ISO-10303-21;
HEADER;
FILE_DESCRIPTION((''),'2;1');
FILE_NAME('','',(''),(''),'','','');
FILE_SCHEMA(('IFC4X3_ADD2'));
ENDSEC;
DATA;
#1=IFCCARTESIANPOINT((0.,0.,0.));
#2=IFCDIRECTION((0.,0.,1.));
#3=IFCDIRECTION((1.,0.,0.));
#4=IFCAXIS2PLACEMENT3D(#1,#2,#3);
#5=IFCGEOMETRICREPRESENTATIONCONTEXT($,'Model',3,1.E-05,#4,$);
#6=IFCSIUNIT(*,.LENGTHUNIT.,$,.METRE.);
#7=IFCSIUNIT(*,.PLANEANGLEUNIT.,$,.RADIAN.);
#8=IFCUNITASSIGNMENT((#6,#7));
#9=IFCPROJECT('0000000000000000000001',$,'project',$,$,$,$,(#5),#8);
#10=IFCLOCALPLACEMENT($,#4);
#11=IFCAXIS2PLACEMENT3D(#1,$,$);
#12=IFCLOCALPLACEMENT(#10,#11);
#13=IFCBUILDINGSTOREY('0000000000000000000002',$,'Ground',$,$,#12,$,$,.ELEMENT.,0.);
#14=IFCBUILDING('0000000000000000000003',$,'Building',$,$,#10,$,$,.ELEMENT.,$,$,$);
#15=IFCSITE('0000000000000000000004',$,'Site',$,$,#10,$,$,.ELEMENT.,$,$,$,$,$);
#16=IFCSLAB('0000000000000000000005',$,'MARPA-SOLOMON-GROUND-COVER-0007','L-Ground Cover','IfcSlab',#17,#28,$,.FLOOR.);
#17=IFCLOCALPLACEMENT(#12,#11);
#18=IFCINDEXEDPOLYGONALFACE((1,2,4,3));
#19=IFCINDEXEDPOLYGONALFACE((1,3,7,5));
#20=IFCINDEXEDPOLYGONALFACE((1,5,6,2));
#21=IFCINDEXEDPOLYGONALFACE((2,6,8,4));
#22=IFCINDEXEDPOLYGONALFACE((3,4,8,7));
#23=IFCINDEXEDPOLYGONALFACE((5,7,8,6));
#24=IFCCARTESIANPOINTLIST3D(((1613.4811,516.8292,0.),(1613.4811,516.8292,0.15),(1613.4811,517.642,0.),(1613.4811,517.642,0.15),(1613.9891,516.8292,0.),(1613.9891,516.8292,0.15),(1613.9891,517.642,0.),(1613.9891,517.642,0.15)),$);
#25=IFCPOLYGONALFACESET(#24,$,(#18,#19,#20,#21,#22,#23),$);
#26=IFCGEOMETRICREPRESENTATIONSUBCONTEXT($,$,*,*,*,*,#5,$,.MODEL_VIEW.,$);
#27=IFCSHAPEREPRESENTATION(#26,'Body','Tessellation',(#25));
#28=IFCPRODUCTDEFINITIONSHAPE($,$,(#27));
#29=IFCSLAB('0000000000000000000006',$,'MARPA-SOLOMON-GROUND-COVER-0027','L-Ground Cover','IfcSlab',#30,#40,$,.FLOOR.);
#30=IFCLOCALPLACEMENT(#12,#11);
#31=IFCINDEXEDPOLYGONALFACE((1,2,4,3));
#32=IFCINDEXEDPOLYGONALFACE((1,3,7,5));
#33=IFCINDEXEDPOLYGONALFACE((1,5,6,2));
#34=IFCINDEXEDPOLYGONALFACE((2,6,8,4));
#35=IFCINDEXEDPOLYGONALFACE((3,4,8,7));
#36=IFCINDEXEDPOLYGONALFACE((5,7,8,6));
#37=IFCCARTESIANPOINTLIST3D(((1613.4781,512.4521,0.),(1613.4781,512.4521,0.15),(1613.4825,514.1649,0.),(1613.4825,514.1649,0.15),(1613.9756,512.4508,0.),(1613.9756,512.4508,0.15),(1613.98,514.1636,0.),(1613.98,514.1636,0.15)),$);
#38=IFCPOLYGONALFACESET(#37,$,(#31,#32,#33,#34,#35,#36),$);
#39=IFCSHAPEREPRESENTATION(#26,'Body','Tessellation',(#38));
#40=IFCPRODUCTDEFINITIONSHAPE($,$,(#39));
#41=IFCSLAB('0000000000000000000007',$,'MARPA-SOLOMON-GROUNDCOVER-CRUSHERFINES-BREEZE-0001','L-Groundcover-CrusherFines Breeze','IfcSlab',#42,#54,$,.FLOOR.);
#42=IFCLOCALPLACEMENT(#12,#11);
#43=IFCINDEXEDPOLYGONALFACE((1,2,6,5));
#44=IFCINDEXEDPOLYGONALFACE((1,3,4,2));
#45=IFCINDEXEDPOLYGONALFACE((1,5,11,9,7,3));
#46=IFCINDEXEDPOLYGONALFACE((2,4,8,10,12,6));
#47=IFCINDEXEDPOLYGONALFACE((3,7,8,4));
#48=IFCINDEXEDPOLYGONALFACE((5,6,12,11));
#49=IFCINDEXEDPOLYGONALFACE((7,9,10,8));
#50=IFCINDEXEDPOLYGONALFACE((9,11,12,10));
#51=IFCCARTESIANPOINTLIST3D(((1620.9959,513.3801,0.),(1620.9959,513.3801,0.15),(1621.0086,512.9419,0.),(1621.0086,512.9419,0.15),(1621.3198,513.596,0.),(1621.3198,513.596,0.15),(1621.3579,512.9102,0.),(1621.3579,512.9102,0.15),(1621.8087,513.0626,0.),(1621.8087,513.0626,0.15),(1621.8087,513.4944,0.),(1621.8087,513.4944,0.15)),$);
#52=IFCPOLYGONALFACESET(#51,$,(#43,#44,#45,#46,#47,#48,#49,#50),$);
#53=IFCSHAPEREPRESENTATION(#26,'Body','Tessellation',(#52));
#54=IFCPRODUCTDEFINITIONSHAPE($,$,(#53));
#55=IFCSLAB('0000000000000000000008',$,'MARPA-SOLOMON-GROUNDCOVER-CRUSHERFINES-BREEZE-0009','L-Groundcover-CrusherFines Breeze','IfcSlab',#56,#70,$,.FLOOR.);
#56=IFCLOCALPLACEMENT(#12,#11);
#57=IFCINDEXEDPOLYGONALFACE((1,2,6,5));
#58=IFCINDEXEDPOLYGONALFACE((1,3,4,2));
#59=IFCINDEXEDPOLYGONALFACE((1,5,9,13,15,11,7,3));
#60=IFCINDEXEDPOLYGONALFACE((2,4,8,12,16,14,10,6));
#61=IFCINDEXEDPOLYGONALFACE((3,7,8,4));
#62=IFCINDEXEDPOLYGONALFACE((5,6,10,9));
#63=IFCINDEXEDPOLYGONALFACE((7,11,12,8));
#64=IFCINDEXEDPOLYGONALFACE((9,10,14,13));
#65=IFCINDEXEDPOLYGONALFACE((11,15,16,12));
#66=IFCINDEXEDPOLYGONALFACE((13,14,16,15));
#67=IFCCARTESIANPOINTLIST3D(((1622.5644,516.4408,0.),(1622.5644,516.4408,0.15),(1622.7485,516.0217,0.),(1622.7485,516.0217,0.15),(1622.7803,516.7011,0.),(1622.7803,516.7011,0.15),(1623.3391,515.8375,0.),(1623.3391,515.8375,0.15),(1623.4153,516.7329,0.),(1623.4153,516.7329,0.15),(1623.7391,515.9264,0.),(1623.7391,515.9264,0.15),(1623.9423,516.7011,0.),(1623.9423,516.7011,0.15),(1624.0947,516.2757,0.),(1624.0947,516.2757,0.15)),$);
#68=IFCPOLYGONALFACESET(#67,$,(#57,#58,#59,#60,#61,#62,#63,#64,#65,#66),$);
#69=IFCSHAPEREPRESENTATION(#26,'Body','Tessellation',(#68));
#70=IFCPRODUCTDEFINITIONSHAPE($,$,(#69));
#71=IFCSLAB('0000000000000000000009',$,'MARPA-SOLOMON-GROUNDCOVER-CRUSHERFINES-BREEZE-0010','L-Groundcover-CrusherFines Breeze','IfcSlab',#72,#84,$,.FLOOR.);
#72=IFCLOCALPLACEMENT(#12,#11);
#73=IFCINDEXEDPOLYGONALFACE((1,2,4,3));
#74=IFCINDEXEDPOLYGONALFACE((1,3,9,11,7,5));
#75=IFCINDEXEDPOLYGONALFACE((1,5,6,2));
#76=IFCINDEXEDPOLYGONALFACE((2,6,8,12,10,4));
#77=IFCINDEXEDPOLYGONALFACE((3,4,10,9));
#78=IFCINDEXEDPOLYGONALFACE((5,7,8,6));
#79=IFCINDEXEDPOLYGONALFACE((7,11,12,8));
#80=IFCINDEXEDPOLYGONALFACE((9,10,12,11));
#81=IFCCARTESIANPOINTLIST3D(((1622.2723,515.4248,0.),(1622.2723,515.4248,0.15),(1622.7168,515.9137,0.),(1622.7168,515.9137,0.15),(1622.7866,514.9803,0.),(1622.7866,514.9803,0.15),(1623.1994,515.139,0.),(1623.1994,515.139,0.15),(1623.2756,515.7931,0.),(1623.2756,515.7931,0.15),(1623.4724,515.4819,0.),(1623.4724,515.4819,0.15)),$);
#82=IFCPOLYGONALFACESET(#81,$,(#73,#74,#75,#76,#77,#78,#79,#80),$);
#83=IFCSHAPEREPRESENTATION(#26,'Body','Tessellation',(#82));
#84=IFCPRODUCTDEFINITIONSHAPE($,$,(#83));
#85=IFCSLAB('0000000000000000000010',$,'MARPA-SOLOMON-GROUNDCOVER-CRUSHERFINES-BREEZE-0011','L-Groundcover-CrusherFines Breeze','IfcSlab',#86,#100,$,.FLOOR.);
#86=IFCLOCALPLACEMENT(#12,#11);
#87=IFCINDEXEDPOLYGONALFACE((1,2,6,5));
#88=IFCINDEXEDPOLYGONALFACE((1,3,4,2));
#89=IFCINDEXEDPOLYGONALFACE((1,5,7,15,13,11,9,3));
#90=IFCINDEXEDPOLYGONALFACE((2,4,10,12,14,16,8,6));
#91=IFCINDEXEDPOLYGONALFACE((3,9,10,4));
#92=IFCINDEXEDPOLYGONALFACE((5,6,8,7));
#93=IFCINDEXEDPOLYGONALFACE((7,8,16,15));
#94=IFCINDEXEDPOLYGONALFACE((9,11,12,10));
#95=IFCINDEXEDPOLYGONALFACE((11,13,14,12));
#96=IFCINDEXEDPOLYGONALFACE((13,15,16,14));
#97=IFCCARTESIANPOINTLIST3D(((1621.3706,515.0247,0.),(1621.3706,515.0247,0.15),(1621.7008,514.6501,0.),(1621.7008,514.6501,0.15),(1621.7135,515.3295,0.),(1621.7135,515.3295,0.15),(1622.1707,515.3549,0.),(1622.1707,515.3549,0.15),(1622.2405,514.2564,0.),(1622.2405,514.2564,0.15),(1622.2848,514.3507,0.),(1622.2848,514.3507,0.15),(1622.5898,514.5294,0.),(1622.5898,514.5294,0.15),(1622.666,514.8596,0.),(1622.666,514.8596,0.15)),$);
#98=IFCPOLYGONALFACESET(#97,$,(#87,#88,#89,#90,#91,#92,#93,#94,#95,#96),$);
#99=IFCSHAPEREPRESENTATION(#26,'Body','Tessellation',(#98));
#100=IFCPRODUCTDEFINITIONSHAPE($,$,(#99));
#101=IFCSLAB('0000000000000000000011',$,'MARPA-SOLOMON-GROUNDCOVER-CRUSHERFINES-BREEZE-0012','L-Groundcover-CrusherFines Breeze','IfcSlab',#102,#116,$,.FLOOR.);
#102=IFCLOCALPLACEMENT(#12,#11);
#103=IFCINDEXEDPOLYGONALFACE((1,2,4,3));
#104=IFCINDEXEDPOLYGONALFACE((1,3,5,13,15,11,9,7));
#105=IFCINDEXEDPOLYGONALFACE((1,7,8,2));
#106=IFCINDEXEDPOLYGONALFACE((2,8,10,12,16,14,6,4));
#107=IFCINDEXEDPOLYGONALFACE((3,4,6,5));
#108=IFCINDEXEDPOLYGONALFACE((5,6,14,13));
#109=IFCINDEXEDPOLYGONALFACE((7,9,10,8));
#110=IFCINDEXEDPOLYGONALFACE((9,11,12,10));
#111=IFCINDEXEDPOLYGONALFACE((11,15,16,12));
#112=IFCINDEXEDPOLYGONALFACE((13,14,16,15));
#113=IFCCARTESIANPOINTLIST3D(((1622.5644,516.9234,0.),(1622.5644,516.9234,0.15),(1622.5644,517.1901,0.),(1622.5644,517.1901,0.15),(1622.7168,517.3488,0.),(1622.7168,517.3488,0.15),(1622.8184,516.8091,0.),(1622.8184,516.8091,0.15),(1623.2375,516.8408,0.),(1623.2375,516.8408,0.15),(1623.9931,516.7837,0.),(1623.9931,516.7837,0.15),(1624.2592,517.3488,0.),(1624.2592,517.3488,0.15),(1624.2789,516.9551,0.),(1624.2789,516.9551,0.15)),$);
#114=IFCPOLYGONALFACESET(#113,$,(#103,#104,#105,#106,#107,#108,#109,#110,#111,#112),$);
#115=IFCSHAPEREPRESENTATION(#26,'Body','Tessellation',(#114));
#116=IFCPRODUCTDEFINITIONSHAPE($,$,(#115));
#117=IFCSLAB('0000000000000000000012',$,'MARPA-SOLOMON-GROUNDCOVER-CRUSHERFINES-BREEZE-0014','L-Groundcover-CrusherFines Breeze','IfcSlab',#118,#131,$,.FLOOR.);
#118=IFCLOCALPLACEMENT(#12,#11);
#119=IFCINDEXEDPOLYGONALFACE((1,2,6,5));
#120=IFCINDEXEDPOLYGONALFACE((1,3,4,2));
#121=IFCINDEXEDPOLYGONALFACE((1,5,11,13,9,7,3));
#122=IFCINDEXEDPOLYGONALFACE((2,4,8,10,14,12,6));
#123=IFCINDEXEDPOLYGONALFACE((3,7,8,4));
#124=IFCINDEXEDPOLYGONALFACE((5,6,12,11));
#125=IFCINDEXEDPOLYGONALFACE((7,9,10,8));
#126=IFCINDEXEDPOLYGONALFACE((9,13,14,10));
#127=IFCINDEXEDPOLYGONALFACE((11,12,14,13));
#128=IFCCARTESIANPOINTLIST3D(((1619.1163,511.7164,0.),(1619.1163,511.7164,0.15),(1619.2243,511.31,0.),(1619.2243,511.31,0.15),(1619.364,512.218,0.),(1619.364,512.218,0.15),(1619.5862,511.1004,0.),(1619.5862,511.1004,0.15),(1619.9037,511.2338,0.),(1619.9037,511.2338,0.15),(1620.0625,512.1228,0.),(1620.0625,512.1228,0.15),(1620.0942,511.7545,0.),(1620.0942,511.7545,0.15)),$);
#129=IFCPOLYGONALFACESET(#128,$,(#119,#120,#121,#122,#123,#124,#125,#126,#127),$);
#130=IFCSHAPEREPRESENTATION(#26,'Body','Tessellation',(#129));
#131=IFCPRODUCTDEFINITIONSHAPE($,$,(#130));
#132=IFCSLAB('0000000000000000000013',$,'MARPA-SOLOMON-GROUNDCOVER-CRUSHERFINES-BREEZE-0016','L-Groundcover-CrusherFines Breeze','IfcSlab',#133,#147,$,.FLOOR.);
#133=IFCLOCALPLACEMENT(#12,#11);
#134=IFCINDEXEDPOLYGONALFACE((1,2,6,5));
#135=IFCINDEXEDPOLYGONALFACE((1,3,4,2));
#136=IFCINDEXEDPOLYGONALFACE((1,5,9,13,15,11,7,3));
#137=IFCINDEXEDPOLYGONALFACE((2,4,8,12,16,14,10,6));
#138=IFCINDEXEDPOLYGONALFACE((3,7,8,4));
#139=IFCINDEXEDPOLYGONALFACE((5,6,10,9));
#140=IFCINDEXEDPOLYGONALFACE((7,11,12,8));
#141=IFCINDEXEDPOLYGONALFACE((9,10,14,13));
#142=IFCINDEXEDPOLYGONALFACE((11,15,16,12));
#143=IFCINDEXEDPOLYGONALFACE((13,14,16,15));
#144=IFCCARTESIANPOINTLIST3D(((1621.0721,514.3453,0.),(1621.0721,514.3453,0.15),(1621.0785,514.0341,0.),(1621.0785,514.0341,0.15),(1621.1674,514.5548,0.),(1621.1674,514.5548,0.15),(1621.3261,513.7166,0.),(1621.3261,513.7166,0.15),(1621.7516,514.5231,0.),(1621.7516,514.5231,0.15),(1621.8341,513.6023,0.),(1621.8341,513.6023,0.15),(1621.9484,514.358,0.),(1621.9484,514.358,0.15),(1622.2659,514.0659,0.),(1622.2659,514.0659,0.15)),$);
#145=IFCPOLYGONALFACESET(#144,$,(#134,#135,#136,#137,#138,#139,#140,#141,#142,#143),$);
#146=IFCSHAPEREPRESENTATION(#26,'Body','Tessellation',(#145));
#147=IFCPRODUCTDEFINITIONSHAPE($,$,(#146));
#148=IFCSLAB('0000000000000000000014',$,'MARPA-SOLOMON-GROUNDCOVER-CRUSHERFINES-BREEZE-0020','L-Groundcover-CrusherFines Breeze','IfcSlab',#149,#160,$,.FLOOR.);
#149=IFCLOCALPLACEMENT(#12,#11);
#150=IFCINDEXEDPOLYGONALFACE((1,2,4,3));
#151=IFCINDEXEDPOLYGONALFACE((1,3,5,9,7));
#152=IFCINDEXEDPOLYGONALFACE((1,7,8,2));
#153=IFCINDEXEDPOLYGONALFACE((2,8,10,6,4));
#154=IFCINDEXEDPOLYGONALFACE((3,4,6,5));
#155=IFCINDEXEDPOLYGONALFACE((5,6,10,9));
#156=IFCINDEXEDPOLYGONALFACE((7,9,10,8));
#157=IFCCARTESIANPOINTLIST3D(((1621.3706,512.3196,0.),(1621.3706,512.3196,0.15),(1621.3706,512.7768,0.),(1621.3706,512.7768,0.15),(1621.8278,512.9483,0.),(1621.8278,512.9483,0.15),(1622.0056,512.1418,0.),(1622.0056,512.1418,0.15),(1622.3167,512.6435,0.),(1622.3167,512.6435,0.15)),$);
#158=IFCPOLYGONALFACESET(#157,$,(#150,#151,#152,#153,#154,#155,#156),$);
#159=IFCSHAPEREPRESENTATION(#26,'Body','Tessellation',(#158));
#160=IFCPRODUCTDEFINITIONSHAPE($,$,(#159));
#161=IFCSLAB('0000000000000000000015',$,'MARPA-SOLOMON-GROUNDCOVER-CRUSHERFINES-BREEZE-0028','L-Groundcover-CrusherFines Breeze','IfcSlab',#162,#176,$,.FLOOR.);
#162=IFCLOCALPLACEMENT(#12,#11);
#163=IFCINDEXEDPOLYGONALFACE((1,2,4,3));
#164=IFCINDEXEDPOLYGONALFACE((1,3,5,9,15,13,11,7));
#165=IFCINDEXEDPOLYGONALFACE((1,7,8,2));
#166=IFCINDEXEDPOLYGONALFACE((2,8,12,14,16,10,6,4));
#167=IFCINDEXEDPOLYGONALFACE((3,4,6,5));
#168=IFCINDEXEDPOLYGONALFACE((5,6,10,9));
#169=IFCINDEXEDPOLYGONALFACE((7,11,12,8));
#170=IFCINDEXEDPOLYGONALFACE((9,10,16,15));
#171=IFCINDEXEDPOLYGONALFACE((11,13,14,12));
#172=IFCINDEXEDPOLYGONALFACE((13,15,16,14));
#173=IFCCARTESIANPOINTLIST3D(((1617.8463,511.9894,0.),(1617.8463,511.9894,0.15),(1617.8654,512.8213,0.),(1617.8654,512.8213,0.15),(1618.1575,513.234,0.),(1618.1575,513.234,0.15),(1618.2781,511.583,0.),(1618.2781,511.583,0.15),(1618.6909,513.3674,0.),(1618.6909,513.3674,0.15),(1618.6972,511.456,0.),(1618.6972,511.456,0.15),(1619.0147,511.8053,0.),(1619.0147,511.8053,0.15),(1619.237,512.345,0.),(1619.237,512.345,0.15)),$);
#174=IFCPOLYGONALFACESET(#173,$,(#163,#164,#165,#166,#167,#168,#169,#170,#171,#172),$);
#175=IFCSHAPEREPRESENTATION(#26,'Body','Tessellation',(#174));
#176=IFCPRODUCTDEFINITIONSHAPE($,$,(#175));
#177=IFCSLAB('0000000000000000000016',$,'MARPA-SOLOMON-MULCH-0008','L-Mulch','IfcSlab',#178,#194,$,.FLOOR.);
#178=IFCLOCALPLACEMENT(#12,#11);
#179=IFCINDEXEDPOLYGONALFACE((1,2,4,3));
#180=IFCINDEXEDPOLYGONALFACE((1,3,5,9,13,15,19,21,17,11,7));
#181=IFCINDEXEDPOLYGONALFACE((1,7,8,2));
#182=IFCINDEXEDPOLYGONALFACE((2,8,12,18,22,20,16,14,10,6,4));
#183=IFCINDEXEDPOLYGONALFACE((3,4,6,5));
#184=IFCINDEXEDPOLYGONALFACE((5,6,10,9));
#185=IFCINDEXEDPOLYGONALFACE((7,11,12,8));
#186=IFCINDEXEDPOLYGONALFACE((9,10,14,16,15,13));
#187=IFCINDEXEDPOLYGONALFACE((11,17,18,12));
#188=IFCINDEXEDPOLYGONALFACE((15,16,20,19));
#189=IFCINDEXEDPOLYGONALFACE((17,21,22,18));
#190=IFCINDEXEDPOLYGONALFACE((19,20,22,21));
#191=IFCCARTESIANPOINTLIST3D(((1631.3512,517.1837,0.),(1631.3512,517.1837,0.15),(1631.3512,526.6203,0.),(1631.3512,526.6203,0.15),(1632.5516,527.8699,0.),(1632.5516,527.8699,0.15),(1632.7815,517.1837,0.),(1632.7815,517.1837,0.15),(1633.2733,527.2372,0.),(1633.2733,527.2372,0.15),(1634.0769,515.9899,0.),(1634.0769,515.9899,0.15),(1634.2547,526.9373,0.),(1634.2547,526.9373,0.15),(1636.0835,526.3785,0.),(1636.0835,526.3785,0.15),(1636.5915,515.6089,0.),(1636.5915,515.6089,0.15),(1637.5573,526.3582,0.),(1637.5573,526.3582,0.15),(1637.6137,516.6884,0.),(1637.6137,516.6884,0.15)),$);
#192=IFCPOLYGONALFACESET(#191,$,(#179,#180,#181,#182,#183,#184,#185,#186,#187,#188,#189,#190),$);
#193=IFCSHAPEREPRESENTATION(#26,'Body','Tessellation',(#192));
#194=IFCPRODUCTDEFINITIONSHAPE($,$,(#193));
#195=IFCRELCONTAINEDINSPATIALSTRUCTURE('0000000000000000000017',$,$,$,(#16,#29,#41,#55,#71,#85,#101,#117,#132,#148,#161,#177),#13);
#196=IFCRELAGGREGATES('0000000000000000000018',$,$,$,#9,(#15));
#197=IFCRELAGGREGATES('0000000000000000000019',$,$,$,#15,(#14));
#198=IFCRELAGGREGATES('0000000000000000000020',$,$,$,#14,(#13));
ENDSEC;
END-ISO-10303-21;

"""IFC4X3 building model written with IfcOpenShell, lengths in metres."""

from ifc_helpers import new_model, si_unit, frame, origin, origin_with_axes, place, context, subcontext, project, spatial, polyline, outline, extrude, element, save


model = new_model("IFC4X3")

# Units and contexts
model_context = context("Model", 3, precision=1e-05, world=origin_with_axes())
sub_context = subcontext(model_context, None, None, "MODEL_VIEW")
ifc_project = project(units=[si_unit("LENGTHUNIT", "METRE"), si_unit("PLANEANGLEUNIT", "RADIAN")], contexts=[model_context])

# Site, building, storey
placement = place(None, origin_with_axes())
site = spatial("IfcSite", under=ifc_project, at=placement, Name="Site", CompositionType="ELEMENT")
building = spatial("IfcBuilding", under=site, at=placement, Name="Building", CompositionType="ELEMENT")
storey_placement = place(placement, origin())
storey = spatial("IfcBuildingStorey", under=building, at=storey_placement, Name="Ground", CompositionType="ELEMENT", Elevation=0.0)

# Slabs
slab_1_placement = place(storey_placement, frame((1613.4811, 516.8292, 0.0)))
element("IfcSlab", 1, at=slab_1_placement, inside=storey, Name="MARPA-SOLOMON-GROUND-COVER-0007", Description="L-Ground Cover", ObjectType="IfcSlab", PredefinedType="FLOOR", context=sub_context, shape_type="SweptSolid", body=[
    extrude(outline(polyline([(0.0, 0.8128), (0.508, 0.8128), (0.508, 0.0), (0.0, 0.0), (0.0, 0.8128)])), origin(), (0.0, 0.0, 1.0), 0.15),
])
slab_2_placement = place(storey_placement, frame((1613.4781, 512.4508, 0.0)))
element("IfcSlab", 2, at=slab_2_placement, inside=storey, Name="MARPA-SOLOMON-GROUND-COVER-0027", Description="L-Ground Cover", ObjectType="IfcSlab", PredefinedType="FLOOR", context=sub_context, shape_type="SweptSolid", body=[
    extrude(outline(polyline([(0.502, 1.7128), (0.4976, 0.0), (0.0, 0.0013), (0.0044, 1.7141), (0.502, 1.7128)])), origin(), (0.0, 0.0, 1.0), 0.15),
])
slab_3_placement = place(storey_placement, frame((1620.9959, 512.9102, 0.0)))
element("IfcSlab", 3, at=slab_3_placement, inside=storey, Name="MARPA-SOLOMON-GROUNDCOVER-CRUSHERFINES-BREEZE-0001", Description="L-Groundcover-CrusherFines Breeze", ObjectType="IfcSlab", PredefinedType="FLOOR", context=sub_context, shape_type="SweptSolid", body=[
    extrude(outline(polyline([(0.3619, 0.0), (0.8128, 0.1524), (0.8128, 0.5842), (0.3238, 0.6858), (0.0, 0.4699), (0.0127, 0.0317), (0.3619, 0.0)])), origin(), (0.0, 0.0, 1.0), 0.15),
])
slab_4_placement = place(storey_placement, frame((1622.5644, 515.8375, 0.0)))
element("IfcSlab", 4, at=slab_4_placement, inside=storey, Name="MARPA-SOLOMON-GROUNDCOVER-CRUSHERFINES-BREEZE-0009", Description="L-Groundcover-CrusherFines Breeze", ObjectType="IfcSlab", PredefinedType="FLOOR", context=sub_context, shape_type="SweptSolid", body=[
    extrude(outline(polyline([(0.1842, 0.1842), (0.0, 0.6033), (0.2159, 0.8636), (0.8509, 0.8954), (1.3779, 0.8636), (1.5303, 0.4382), (1.1747, 0.0889), (0.7747, 0.0), (0.1842, 0.1842)])), origin(), (0.0, 0.0, 1.0), 0.15),
])
slab_5_placement = place(storey_placement, frame((1622.2723, 514.9803, 0.0)))
element("IfcSlab", 5, at=slab_5_placement, inside=storey, Name="MARPA-SOLOMON-GROUNDCOVER-CRUSHERFINES-BREEZE-0010", Description="L-Groundcover-CrusherFines Breeze", ObjectType="IfcSlab", PredefinedType="FLOOR", context=sub_context, shape_type="SweptSolid", body=[
    extrude(outline(polyline([(0.0, 0.4445), (0.4445, 0.9335), (1.0033, 0.8128), (1.2001, 0.5017), (0.9271, 0.1588), (0.5143, 0.0), (0.0, 0.4445)])), origin(), (0.0, 0.0, 1.0), 0.15),
])
slab_6_placement = place(storey_placement, frame((1621.3706, 514.2564, 0.0)))
element("IfcSlab", 6, at=slab_6_placement, inside=storey, Name="MARPA-SOLOMON-GROUNDCOVER-CRUSHERFINES-BREEZE-0011", Description="L-Groundcover-CrusherFines Breeze", ObjectType="IfcSlab", PredefinedType="FLOOR", context=sub_context, shape_type="SweptSolid", body=[
    extrude(outline(polyline([(0.87, 0.0), (0.3302, 0.3937), (0.0, 0.7684), (0.3429, 1.0732), (0.8001, 1.0986), (1.2954, 0.6033), (1.2192, 0.2731), (0.9143, 0.0943), (0.87, 0.0)])), origin(), (0.0, 0.0, 1.0), 0.15),
])
slab_7_placement = place(storey_placement, frame((1622.5644, 516.7837, 0.0)))
element("IfcSlab", 7, at=slab_7_placement, inside=storey, Name="MARPA-SOLOMON-GROUNDCOVER-CRUSHERFINES-BREEZE-0012", Description="L-Groundcover-CrusherFines Breeze", ObjectType="IfcSlab", PredefinedType="FLOOR", context=sub_context, shape_type="SweptSolid", body=[
    extrude(outline(polyline([(0.254, 0.0254), (0.0, 0.1397), (0.0, 0.4064), (0.1524, 0.5651), (1.6948, 0.5651), (1.7145, 0.1714), (1.4288, 0.0), (0.6731, 0.0571), (0.254, 0.0254)])), origin(), (0.0, 0.0, 1.0), 0.15),
])
slab_8_placement = place(storey_placement, frame((1619.1163, 511.1004, 0.0)))
element("IfcSlab", 8, at=slab_8_placement, inside=storey, Name="MARPA-SOLOMON-GROUNDCOVER-CRUSHERFINES-BREEZE-0014", Description="L-Groundcover-CrusherFines Breeze", ObjectType="IfcSlab", PredefinedType="FLOOR", context=sub_context, shape_type="SweptSolid", body=[
    extrude(outline(polyline([(0.2477, 1.1176), (0.0, 0.6159), (0.108, 0.2095), (0.4699, 0.0), (0.7874, 0.1333), (0.9779, 0.654), (0.9461, 1.0223), (0.2477, 1.1176)])), origin(), (0.0, 0.0, 1.0), 0.15),
])
slab_9_placement = place(storey_placement, frame((1621.0721, 513.6023, 0.0)))
element("IfcSlab", 9, at=slab_9_placement, inside=storey, Name="MARPA-SOLOMON-GROUNDCOVER-CRUSHERFINES-BREEZE-0016", Description="L-Groundcover-CrusherFines Breeze", ObjectType="IfcSlab", PredefinedType="FLOOR", context=sub_context, shape_type="SweptSolid", body=[
    extrude(outline(polyline([(0.254, 0.1143), (0.0064, 0.4318), (0.0, 0.7429), (0.0953, 0.9525), (0.6794, 0.9207), (0.8763, 0.7556), (1.1938, 0.4636), (0.762, 0.0), (0.254, 0.1143)])), origin(), (0.0, 0.0, 1.0), 0.15),
])
slab_10_placement = place(storey_placement, frame((1621.3706, 512.1418, 0.0)))
element("IfcSlab", 10, at=slab_10_placement, inside=storey, Name="MARPA-SOLOMON-GROUNDCOVER-CRUSHERFINES-BREEZE-0020", Description="L-Groundcover-CrusherFines Breeze", ObjectType="IfcSlab", PredefinedType="FLOOR", context=sub_context, shape_type="SweptSolid", body=[
    extrude(outline(polyline([(0.0, 0.1778), (0.635, 0.0), (0.9461, 0.5017), (0.4572, 0.8065), (0.0, 0.635), (0.0, 0.1778)])), origin(), (0.0, 0.0, 1.0), 0.15),
])
slab_11_placement = place(storey_placement, frame((1617.8463, 511.456, 0.0)))
element("IfcSlab", 11, at=slab_11_placement, inside=storey, Name="MARPA-SOLOMON-GROUNDCOVER-CRUSHERFINES-BREEZE-0028", Description="L-Groundcover-CrusherFines Breeze", ObjectType="IfcSlab", PredefinedType="FLOOR", context=sub_context, shape_type="SweptSolid", body=[
    extrude(outline(polyline([(0.0191, 1.3652), (0.0, 0.5334), (0.4318, 0.127), (0.8509, 0.0), (1.1684, 0.3492), (1.3907, 0.889), (0.8446, 1.9113), (0.3112, 1.778), (0.0191, 1.3652)])), origin(), (0.0, 0.0, 1.0), 0.15),
])
slab_12_placement = place(storey_placement, frame((1631.3512, 515.6089, 0.0)))
element("IfcSlab", 12, at=slab_12_placement, inside=storey, Name="MARPA-SOLOMON-MULCH-0008", Description="L-Mulch", ObjectType="IfcSlab", PredefinedType="FLOOR", context=sub_context, shape_type="SweptSolid", body=[
    extrude(outline(polyline([(6.2061, 10.7492), (4.7323, 10.7696), (2.9035, 11.3284), (1.9221, 11.6283), (1.2003, 12.261), (0.0, 11.0114), (0.0, 1.5748), (1.4303, 1.5748), (2.7257, 0.381), (5.2403, 0.0), (6.2625, 1.0795), (6.2061, 10.7492)])), origin(), (0.0, 0.0, 1.0), 0.15),
])

save(model, "model.ifc")
